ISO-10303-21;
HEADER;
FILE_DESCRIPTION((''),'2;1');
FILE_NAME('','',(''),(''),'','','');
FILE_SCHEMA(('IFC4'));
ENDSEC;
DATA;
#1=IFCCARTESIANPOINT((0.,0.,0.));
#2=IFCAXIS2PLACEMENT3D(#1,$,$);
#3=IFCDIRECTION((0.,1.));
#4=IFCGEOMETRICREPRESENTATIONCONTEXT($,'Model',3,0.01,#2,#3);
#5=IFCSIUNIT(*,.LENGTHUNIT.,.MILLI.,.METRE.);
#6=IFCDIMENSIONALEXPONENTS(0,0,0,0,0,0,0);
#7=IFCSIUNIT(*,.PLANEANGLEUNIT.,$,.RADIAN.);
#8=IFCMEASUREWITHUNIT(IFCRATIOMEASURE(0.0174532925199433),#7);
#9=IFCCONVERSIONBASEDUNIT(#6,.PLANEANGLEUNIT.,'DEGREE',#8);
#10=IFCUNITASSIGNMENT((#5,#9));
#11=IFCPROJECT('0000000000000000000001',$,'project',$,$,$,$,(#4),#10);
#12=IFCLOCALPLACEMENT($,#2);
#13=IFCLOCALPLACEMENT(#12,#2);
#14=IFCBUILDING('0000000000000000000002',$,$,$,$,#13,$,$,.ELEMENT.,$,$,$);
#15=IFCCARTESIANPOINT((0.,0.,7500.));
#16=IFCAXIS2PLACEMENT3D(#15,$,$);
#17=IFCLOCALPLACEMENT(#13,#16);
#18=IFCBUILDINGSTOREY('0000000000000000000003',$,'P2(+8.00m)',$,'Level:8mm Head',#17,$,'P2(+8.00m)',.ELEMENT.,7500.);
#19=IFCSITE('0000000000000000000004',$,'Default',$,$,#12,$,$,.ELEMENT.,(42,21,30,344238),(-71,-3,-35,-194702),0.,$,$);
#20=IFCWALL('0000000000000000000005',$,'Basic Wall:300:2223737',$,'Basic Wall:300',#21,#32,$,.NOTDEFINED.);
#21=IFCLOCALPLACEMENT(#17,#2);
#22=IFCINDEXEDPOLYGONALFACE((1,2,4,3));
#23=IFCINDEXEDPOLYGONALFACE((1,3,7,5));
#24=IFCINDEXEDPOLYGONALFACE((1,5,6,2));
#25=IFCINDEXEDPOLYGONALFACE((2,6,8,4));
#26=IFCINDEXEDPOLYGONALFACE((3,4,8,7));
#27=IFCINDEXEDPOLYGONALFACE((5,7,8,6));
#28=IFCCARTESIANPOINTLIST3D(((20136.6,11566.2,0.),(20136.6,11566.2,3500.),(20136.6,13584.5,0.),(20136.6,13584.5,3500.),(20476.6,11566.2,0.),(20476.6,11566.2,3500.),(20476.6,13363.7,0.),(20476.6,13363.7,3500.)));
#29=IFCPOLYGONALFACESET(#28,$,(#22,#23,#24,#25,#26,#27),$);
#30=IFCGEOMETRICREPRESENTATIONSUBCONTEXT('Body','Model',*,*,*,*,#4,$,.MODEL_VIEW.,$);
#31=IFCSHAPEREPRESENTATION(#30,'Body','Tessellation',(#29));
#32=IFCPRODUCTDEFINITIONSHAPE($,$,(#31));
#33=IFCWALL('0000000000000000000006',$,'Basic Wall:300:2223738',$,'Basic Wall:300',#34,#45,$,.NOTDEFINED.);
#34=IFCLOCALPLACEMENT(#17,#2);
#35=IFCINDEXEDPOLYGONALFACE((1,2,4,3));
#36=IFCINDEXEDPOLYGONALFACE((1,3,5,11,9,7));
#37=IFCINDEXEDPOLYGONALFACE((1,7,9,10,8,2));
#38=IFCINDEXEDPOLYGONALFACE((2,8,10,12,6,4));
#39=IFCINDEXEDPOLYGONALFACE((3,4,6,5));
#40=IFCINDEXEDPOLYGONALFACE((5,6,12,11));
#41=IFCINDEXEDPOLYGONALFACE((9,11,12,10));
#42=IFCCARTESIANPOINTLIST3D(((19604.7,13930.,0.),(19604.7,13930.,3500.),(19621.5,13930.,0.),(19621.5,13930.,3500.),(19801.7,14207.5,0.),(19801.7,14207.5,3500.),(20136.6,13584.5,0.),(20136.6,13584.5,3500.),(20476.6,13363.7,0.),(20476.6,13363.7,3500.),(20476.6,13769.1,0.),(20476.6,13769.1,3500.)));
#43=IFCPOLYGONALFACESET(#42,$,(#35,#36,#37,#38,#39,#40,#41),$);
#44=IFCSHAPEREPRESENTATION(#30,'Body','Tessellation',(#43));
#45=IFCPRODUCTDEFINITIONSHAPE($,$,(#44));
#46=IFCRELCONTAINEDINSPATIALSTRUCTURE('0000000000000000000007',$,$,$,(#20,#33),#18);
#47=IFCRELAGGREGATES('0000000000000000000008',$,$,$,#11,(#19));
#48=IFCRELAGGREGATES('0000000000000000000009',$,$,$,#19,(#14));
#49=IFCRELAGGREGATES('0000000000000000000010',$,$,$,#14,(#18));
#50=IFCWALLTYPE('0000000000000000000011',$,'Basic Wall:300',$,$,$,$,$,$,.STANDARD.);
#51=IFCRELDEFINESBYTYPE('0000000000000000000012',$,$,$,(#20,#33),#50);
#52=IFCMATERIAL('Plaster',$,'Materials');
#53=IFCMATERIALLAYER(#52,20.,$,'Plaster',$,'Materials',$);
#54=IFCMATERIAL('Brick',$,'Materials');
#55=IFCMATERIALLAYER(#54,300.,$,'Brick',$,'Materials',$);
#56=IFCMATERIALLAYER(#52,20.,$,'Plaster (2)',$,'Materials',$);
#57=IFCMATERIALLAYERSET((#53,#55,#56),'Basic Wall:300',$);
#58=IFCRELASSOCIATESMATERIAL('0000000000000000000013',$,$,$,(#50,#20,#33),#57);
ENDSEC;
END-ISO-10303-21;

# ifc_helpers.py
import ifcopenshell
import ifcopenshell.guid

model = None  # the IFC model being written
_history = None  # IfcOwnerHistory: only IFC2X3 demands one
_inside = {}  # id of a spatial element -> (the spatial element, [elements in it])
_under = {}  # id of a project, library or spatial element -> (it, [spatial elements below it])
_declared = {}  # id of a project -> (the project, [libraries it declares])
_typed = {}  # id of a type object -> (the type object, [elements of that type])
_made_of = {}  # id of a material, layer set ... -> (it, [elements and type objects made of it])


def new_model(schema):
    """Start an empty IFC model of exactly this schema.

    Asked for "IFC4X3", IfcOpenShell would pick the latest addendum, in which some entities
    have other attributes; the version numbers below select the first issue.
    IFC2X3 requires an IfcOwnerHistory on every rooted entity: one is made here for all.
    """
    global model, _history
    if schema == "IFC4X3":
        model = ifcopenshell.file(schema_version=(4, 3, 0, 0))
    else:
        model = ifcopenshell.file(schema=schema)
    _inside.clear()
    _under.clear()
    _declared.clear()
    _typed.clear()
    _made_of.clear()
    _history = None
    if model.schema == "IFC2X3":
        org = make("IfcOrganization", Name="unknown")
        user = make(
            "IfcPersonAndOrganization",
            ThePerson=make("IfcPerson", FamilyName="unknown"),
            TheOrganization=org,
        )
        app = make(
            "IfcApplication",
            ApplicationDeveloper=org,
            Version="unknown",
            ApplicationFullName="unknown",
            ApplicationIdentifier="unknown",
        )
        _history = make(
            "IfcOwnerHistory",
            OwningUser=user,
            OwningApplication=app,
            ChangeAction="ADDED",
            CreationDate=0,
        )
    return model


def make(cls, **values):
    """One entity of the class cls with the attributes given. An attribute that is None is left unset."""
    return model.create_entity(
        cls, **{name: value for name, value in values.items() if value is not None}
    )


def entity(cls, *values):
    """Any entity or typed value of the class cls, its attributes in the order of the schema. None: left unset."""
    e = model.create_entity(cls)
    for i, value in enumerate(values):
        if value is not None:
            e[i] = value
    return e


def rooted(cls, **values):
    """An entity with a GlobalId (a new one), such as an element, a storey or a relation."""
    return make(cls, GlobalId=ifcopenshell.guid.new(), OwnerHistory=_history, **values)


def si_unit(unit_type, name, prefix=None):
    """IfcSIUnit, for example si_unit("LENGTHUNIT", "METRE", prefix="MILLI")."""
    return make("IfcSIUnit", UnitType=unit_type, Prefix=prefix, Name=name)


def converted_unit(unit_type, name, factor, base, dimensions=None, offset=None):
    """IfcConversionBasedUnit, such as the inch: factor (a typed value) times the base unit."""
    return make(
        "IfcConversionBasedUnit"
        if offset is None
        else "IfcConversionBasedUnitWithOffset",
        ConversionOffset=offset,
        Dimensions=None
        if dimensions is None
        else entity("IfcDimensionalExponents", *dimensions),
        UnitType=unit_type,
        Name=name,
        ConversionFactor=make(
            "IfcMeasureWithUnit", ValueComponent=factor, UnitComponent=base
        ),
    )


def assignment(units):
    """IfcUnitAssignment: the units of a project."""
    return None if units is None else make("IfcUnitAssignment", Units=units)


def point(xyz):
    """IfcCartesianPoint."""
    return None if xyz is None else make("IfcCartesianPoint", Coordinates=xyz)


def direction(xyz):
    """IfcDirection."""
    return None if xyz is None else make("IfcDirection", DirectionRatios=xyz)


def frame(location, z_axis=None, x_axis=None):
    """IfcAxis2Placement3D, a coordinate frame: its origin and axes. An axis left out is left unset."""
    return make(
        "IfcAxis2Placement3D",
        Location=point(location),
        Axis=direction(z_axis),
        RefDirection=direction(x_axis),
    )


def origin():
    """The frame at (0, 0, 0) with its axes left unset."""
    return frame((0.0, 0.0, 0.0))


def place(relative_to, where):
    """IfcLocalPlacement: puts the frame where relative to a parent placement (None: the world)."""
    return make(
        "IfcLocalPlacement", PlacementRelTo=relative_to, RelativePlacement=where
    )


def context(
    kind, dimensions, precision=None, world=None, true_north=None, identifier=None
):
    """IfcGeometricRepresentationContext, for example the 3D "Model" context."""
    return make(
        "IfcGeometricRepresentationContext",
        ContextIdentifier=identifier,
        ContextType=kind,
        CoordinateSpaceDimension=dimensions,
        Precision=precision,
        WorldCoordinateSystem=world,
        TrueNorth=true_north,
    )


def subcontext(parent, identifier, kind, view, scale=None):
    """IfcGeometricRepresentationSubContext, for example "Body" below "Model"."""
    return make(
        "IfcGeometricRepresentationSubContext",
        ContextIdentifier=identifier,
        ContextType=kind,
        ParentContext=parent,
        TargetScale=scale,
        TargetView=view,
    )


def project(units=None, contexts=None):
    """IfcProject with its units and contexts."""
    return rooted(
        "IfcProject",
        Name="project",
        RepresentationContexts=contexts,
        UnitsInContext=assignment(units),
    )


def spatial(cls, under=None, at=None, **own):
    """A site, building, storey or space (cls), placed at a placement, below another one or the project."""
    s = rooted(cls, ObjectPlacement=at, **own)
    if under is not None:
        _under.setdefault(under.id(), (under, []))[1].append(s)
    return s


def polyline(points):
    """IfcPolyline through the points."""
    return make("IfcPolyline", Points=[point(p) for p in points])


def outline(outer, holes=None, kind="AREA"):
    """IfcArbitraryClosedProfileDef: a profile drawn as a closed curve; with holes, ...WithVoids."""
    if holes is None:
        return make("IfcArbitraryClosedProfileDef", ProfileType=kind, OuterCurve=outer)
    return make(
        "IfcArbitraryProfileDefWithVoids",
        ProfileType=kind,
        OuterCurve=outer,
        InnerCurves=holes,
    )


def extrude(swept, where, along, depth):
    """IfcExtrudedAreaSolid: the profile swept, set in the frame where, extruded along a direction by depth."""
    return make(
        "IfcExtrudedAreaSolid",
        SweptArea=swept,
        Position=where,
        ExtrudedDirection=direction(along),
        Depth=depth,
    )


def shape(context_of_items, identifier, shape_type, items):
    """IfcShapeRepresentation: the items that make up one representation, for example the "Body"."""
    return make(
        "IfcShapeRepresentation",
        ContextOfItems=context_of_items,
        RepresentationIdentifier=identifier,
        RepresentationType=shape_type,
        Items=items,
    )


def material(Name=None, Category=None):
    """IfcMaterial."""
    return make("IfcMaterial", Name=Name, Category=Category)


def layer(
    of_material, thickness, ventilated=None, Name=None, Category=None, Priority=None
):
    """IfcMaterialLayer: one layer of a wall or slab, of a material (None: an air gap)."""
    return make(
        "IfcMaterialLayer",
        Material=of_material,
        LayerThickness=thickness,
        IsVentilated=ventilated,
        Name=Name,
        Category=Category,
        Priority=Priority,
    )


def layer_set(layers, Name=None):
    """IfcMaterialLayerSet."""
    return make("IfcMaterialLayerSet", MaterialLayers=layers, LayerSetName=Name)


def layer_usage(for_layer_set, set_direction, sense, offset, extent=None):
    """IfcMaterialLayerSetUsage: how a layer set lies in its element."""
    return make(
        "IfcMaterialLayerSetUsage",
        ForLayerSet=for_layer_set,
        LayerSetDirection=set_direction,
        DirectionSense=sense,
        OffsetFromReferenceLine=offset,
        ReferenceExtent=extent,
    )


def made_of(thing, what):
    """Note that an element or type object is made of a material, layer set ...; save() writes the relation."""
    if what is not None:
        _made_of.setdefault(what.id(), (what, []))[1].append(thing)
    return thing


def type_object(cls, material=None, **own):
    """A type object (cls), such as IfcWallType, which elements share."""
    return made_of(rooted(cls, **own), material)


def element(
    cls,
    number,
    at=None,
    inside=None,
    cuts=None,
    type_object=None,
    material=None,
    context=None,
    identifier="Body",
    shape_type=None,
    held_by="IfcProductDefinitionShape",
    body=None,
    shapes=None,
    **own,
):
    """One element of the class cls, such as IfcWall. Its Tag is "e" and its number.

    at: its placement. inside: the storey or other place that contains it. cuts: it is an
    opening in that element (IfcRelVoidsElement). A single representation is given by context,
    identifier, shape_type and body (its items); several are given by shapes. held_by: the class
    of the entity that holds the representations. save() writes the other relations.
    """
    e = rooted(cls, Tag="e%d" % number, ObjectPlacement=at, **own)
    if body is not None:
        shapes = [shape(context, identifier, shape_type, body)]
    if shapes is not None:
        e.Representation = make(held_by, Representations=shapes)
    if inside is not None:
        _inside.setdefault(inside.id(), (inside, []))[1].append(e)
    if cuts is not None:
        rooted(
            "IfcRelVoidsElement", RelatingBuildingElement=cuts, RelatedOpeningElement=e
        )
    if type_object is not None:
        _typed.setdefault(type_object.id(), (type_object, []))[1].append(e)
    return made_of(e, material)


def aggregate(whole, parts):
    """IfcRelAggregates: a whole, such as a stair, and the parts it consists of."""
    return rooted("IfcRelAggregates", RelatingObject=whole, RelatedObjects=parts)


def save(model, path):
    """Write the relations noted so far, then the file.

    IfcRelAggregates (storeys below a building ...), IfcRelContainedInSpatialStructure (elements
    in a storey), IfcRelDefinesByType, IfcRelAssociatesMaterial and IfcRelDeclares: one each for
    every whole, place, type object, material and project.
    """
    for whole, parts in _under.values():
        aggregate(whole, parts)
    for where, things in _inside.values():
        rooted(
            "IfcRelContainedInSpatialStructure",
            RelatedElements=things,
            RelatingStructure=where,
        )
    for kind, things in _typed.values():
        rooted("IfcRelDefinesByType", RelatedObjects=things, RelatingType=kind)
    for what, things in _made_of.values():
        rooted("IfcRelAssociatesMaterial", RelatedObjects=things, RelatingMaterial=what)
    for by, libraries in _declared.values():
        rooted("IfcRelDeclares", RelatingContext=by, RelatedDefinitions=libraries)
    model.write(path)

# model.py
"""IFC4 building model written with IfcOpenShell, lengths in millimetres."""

from ifc_helpers import new_model, entity, si_unit, converted_unit, direction, frame, origin, place, context, subcontext, project, spatial, polyline, outline, extrude, material, layer, layer_set, layer_usage, type_object, element, save


model = new_model("IFC4")

# Units and contexts
model_context = context("Model", 3, precision=0.01, world=origin(), true_north=direction((0.0, 1.0)))
body_context = subcontext(model_context, "Body", "Model", "MODEL_VIEW")
ifc_project = project(units=[si_unit("LENGTHUNIT", "METRE", prefix="MILLI"), converted_unit("PLANEANGLEUNIT", "DEGREE", entity("IfcRatioMeasure", 0.0174532925199433), si_unit("PLANEANGLEUNIT", "RADIAN"), dimensions=[0, 0, 0, 0, 0, 0, 0])], contexts=[model_context])

# Site, building, storey
site_placement = place(None, origin())
site = spatial("IfcSite", under=ifc_project, at=site_placement, Name="Default", CompositionType="ELEMENT", RefLatitude=(42, 21, 30, 344238), RefLongitude=(-71, -3, -35, -194702), RefElevation=0.0)
building_placement = place(site_placement, origin())
building = spatial("IfcBuilding", under=site, at=building_placement, CompositionType="ELEMENT")
storey_placement = place(building_placement, frame((0.0, 0.0, 7500.0)))
storey = spatial("IfcBuildingStorey", under=building, at=storey_placement, Name="P2(+8.00m)", ObjectType="Level:8mm Head", LongName="P2(+8.00m)", CompositionType="ELEMENT", Elevation=7500.0)

# Shared definitions
ifc_material_1 = material(Name="Brick", Category="Materials")
ifc_material_2 = material(Name="Plaster", Category="Materials")

# Walls
ifc_layer_1 = layer(ifc_material_2, 20.0, Name="Plaster", Category="Materials")
ifc_layer_2 = layer(ifc_material_1, 300.0, Name="Brick", Category="Materials")
ifc_layer_3 = layer(ifc_material_2, 20.0, Name="Plaster (2)", Category="Materials")
ifc_layer_set_1 = layer_set([ifc_layer_1, ifc_layer_2, ifc_layer_3], Name="Basic Wall:300")
ifc_layer_usage_1 = layer_usage(ifc_layer_set_1, "AXIS2", "POSITIVE", -170.0)
wall_type_1 = type_object("IfcWallType", Name="Basic Wall:300", PredefinedType="STANDARD", material=ifc_layer_set_1)
wall_1_placement = place(storey_placement, frame((20306.6, 11566.2, 0.0), z_axis=(0.0, 0.0, 1.0), x_axis=(0.0, 1.0, 0.0)))
element("IfcWall", 1, at=wall_1_placement, inside=storey, type_object=wall_type_1, material=ifc_layer_usage_1, Name="Basic Wall:300:2223737", ObjectType="Basic Wall:300", PredefinedType="NOTDEFINED", context=body_context, shape_type="SweptSolid", body=[
    extrude(outline(polyline([(1797.5, -170.0), (2018.3, 170.0), (0.0, 170.0), (0.0, -170.0), (1797.5, -170.0)])), origin(), (0.0, 0.0, 1.0), 3500.0),
])
ifc_layer_usage_2 = layer_usage(ifc_layer_set_1, "AXIS2", "POSITIVE", -170.0)
wall_2_placement = place(storey_placement, frame((20569.2, 13506.3, 0.0), z_axis=(0.0, 0.0, 1.0), x_axis=(-0.838671, 0.544639, 0.0)))
element("IfcWall", 2, at=wall_2_placement, inside=storey, type_object=wall_type_1, material=ifc_layer_usage_2, Name="Basic Wall:300:2223738", ObjectType="Basic Wall:300", PredefinedType="NOTDEFINED", context=body_context, shape_type="SweptSolid", body=[
    extrude(outline(polyline([(1025.6, -170.0), (1025.6, 160.9), (1039.7, 170.0), (405.4, 170.0), (0.0, 170.0), (220.8, -170.0), (1025.6, -170.0)])), origin(), (0.0, 0.0, 1.0), 3500.0),
])

save(model, "model.ifc")
